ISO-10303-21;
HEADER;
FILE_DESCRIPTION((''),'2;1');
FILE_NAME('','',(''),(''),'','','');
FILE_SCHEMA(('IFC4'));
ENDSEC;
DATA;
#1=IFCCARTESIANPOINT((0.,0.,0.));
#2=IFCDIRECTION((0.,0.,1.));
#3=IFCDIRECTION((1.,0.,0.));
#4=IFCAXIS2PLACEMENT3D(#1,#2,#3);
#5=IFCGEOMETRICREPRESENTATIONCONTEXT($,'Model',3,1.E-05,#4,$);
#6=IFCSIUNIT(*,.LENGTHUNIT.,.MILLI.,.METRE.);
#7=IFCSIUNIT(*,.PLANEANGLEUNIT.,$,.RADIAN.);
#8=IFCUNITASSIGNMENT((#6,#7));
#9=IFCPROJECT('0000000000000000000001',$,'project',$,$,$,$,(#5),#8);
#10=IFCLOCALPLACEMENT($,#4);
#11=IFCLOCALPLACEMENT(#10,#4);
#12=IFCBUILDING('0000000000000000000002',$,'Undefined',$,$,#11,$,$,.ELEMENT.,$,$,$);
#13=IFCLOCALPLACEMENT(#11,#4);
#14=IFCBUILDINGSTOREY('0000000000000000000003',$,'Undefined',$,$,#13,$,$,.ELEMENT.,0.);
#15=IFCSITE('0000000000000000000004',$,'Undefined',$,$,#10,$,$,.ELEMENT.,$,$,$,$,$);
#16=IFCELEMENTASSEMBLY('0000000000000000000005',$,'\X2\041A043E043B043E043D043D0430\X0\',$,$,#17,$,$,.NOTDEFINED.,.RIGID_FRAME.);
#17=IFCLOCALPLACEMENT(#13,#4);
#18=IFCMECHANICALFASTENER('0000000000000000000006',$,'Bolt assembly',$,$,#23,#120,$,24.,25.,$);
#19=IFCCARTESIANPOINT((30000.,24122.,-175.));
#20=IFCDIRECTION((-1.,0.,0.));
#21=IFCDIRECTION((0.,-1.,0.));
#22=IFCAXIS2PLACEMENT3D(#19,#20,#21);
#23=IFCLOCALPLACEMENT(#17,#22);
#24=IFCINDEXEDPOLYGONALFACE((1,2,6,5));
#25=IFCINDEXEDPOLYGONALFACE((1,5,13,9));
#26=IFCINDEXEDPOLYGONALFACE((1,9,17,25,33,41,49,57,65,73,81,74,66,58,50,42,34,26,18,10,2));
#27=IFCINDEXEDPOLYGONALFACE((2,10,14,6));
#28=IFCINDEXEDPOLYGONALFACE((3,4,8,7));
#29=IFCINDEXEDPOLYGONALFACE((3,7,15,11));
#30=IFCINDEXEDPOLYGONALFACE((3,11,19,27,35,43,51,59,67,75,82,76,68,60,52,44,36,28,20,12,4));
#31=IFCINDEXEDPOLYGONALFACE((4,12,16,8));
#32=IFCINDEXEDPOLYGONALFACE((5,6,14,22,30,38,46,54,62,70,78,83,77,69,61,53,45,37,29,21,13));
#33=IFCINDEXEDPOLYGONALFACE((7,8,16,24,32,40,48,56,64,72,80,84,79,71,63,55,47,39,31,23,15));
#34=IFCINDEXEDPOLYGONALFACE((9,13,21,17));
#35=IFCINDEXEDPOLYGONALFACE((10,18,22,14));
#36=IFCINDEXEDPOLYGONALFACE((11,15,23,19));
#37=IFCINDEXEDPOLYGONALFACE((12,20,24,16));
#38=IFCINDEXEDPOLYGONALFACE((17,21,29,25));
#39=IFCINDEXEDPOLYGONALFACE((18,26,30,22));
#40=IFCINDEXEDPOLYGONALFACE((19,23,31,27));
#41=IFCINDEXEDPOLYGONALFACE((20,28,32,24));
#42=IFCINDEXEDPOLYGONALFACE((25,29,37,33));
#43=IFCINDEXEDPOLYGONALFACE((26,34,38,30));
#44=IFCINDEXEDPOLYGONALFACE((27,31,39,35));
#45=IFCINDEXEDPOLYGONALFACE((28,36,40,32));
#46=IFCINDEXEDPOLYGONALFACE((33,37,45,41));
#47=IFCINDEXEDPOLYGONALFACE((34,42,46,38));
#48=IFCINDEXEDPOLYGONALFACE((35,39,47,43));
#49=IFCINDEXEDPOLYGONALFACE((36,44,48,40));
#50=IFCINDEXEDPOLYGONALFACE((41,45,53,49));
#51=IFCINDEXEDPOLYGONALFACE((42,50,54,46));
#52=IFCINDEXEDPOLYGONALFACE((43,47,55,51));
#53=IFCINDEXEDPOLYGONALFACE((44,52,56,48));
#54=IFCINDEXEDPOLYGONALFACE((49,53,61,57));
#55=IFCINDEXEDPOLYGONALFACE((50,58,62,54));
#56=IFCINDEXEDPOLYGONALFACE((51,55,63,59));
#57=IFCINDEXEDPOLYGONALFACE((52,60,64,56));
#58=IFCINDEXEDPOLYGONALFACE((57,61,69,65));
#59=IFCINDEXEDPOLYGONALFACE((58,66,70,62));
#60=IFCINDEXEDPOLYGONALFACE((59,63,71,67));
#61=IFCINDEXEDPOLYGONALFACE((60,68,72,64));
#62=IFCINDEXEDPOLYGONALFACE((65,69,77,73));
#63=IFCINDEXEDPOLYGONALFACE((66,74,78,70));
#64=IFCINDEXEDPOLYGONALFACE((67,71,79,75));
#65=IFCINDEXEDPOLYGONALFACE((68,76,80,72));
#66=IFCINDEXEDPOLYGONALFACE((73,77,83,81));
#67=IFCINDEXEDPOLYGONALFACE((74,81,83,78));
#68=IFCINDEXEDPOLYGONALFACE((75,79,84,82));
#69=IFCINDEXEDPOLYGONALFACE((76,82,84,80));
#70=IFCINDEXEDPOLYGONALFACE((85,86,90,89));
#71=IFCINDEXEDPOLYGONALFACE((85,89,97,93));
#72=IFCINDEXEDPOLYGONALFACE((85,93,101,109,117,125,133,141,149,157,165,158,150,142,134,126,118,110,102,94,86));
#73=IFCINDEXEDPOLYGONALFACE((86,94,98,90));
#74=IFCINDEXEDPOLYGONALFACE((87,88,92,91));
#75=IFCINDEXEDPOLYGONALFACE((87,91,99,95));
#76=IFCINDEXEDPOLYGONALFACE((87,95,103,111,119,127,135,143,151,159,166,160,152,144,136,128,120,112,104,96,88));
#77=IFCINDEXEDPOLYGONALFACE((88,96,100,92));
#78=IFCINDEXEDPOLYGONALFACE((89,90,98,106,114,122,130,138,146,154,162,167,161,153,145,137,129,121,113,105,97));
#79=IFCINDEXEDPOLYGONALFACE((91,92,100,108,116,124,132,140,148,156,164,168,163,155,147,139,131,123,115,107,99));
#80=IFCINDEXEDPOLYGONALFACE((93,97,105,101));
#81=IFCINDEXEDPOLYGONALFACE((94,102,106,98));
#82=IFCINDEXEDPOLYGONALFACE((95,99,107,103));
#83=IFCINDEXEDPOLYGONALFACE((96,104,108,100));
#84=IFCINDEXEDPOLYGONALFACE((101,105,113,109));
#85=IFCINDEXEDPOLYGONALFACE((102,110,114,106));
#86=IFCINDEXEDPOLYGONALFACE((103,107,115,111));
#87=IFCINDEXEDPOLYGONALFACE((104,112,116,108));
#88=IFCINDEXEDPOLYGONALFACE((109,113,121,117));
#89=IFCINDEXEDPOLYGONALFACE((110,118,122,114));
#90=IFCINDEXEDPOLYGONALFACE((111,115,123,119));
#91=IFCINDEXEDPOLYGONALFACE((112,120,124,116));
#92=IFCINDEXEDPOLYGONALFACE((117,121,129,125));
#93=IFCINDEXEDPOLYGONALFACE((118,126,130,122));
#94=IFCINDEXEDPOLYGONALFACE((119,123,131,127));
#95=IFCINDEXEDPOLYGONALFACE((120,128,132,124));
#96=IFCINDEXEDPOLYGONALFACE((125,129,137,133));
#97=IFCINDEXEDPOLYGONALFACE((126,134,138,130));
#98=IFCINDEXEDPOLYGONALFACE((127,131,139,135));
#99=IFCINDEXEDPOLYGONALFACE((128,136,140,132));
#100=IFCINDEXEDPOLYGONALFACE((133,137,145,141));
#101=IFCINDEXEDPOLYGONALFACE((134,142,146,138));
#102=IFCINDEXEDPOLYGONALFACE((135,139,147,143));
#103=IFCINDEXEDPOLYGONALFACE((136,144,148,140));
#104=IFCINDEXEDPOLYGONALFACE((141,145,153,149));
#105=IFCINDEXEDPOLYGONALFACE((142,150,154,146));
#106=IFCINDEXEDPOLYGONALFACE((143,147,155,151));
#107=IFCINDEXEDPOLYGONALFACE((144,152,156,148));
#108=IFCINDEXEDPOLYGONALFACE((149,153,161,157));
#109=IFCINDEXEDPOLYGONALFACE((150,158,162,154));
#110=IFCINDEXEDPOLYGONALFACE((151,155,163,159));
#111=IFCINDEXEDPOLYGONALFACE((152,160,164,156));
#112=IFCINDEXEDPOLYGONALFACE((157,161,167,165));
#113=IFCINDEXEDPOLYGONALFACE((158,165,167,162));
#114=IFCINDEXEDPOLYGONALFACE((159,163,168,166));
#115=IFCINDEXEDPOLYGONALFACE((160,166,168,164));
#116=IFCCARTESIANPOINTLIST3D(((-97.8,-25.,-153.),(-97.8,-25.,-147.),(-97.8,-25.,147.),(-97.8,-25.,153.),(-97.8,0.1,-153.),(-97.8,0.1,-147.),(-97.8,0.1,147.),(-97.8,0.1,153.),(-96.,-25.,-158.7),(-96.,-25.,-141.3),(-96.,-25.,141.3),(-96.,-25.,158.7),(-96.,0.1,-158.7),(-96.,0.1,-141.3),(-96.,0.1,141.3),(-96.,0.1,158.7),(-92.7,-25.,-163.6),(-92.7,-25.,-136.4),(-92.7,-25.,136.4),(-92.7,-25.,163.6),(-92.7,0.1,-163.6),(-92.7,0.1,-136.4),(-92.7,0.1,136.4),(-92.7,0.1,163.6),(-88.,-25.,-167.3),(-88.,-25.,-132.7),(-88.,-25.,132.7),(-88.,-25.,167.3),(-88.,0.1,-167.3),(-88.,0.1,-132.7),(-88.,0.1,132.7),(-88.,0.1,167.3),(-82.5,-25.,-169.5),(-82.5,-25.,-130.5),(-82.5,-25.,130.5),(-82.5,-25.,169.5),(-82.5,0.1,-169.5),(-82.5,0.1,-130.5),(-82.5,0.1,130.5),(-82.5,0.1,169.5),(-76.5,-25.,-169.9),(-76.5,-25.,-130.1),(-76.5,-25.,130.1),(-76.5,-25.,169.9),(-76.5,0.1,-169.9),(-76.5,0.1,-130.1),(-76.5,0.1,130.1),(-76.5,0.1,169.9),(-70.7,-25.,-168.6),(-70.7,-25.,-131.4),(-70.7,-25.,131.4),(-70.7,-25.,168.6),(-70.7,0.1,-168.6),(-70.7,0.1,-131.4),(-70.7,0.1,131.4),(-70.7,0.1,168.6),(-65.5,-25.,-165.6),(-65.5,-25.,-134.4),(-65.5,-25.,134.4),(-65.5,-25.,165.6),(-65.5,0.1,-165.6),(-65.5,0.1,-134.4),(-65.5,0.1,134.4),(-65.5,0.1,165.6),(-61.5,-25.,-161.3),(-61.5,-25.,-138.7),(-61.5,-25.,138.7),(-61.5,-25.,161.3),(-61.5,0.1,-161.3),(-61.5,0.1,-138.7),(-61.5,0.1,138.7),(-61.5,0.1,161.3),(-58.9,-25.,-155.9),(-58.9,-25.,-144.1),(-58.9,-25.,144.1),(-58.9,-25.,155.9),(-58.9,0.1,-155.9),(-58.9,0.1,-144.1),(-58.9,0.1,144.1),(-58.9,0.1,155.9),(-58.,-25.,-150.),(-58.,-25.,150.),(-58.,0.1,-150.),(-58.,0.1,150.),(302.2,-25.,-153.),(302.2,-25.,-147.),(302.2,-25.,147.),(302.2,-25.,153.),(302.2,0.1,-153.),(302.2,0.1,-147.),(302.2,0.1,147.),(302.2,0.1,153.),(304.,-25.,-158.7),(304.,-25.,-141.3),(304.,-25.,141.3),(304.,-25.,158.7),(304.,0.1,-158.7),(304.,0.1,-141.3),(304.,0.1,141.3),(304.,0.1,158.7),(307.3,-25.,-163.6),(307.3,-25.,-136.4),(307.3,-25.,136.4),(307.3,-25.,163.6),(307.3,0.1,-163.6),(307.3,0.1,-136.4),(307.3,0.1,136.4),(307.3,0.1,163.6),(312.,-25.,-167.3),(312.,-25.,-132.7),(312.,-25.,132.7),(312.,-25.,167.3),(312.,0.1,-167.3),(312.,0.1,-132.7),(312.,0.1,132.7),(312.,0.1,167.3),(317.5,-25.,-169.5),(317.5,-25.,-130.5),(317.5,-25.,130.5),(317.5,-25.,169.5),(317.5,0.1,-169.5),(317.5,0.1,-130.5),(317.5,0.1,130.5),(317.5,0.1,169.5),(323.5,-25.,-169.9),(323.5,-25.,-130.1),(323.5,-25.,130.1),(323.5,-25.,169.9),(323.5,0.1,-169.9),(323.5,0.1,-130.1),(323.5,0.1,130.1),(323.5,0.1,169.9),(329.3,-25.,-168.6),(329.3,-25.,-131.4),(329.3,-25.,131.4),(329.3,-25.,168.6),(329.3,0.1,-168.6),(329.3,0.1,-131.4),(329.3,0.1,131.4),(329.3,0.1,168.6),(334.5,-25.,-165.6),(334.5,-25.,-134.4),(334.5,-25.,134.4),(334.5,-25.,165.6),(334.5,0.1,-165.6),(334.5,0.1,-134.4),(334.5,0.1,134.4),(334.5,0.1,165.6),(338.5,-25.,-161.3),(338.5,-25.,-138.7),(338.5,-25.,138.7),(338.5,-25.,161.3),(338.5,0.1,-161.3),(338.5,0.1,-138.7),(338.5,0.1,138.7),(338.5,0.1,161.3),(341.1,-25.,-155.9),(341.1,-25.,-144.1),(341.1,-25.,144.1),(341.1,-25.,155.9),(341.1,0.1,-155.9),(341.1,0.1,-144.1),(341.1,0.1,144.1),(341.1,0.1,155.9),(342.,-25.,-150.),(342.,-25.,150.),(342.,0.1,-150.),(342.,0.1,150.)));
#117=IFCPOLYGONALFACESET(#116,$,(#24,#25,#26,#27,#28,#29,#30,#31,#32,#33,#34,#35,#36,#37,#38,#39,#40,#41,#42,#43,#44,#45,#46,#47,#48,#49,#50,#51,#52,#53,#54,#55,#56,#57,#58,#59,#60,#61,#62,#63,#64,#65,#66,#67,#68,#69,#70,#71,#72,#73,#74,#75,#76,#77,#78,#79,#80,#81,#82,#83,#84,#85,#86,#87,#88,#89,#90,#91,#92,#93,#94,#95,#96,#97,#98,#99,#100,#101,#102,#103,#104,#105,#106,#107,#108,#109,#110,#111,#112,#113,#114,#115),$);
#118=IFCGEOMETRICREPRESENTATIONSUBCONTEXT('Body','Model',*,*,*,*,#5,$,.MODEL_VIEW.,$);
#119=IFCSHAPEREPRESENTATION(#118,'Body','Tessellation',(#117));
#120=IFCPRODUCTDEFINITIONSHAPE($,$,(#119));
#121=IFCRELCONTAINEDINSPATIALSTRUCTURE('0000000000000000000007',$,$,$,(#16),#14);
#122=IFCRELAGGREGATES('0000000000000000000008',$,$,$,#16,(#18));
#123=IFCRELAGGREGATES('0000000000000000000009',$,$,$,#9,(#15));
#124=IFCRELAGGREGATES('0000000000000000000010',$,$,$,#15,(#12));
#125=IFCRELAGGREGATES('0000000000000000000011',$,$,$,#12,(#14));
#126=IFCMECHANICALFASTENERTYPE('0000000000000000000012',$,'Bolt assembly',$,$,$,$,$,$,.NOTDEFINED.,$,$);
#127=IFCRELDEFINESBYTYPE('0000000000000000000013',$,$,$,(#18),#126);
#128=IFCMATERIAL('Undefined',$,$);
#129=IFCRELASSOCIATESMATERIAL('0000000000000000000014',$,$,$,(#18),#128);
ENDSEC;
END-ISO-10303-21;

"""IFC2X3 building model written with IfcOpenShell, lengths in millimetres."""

from ifc_helpers import new_model, si_unit, frame, origin_with_axes, origin_2d_with_axis, place, context, subcontext, project, spatial, circle, extrude, source, transform, mapped, material, type_object, element, aggregate, save


model = new_model("IFC2X3")

# Units and contexts
model_context = context("Model", 3, precision=1e-05, world=origin_with_axes())
body_context = subcontext(model_context, "Body", "Model", "MODEL_VIEW")
ifc_project = project(units=[si_unit("LENGTHUNIT", "METRE", prefix="MILLI"), si_unit("PLANEANGLEUNIT", "RADIAN")], contexts=[model_context])

# Site, building, storey
site_placement = place(None, origin_with_axes())
site = spatial("IfcSite", under=ifc_project, at=site_placement, Name="Undefined", CompositionType="ELEMENT")
building_placement = place(site_placement, origin_with_axes())
building = spatial("IfcBuilding", under=site, at=building_placement, Name="Undefined", CompositionType="ELEMENT")
storey_placement = place(building_placement, origin_with_axes())
storey = spatial("IfcBuildingStorey", under=building, at=storey_placement, Name="Undefined", CompositionType="ELEMENT", Elevation=0.0)

# Element assembly
assembly_1_placement = place(storey_placement, origin_with_axes())
assembly_1 = element("IfcElementAssembly", 1, at=assembly_1_placement, inside=storey, Name="Колонна", AssemblyPlace="NOTDEFINED", PredefinedType="RIGID_FRAME")

# Mechanical fastener
ifc_material_1 = material(Name="Undefined")
mechanical_fastener_type = type_object("IfcMechanicalFastenerType", Name="Bolt assembly")
shared_shape_1 = source(origin_with_axes(), body_context, "Body", "SweptSolid", [
    extrude(circle(Radius=20.0, at=origin_2d_with_axis()), frame((0.0, -25.0, 0.0), z_axis=(0.0, 1.0, 0.0), x_axis=(1.0, 0.0, 0.0)), (0.0, 0.0, 1.0), 25.1),
])
mechanical_fastener_1_placement = place(assembly_1_placement, frame((30000.0, 24122.0, -175.0), z_axis=(-1.0, 0.0, 0.0), x_axis=(0.0, -1.0, 0.0)))
mechanical_fastener_1 = element("IfcMechanicalFastener", 2, at=mechanical_fastener_1_placement, type_object=mechanical_fastener_type, material=ifc_material_1, Name="Bolt assembly", NominalDiameter=24.0, NominalLength=25.0, context=body_context, shape_type="MappedRepresentation", body=[
    mapped(shared_shape_1, transform((-78.0, 0.0, -150.0))),
    mapped(shared_shape_1, transform((-78.0, 0.0, 150.0))),
    mapped(shared_shape_1, transform((322.0, 0.0, -150.0))),
    mapped(shared_shape_1, transform((322.0, 0.0, 150.0))),
])
aggregate(assembly_1, [mechanical_fastener_1])

save(model, "model.ifc")
